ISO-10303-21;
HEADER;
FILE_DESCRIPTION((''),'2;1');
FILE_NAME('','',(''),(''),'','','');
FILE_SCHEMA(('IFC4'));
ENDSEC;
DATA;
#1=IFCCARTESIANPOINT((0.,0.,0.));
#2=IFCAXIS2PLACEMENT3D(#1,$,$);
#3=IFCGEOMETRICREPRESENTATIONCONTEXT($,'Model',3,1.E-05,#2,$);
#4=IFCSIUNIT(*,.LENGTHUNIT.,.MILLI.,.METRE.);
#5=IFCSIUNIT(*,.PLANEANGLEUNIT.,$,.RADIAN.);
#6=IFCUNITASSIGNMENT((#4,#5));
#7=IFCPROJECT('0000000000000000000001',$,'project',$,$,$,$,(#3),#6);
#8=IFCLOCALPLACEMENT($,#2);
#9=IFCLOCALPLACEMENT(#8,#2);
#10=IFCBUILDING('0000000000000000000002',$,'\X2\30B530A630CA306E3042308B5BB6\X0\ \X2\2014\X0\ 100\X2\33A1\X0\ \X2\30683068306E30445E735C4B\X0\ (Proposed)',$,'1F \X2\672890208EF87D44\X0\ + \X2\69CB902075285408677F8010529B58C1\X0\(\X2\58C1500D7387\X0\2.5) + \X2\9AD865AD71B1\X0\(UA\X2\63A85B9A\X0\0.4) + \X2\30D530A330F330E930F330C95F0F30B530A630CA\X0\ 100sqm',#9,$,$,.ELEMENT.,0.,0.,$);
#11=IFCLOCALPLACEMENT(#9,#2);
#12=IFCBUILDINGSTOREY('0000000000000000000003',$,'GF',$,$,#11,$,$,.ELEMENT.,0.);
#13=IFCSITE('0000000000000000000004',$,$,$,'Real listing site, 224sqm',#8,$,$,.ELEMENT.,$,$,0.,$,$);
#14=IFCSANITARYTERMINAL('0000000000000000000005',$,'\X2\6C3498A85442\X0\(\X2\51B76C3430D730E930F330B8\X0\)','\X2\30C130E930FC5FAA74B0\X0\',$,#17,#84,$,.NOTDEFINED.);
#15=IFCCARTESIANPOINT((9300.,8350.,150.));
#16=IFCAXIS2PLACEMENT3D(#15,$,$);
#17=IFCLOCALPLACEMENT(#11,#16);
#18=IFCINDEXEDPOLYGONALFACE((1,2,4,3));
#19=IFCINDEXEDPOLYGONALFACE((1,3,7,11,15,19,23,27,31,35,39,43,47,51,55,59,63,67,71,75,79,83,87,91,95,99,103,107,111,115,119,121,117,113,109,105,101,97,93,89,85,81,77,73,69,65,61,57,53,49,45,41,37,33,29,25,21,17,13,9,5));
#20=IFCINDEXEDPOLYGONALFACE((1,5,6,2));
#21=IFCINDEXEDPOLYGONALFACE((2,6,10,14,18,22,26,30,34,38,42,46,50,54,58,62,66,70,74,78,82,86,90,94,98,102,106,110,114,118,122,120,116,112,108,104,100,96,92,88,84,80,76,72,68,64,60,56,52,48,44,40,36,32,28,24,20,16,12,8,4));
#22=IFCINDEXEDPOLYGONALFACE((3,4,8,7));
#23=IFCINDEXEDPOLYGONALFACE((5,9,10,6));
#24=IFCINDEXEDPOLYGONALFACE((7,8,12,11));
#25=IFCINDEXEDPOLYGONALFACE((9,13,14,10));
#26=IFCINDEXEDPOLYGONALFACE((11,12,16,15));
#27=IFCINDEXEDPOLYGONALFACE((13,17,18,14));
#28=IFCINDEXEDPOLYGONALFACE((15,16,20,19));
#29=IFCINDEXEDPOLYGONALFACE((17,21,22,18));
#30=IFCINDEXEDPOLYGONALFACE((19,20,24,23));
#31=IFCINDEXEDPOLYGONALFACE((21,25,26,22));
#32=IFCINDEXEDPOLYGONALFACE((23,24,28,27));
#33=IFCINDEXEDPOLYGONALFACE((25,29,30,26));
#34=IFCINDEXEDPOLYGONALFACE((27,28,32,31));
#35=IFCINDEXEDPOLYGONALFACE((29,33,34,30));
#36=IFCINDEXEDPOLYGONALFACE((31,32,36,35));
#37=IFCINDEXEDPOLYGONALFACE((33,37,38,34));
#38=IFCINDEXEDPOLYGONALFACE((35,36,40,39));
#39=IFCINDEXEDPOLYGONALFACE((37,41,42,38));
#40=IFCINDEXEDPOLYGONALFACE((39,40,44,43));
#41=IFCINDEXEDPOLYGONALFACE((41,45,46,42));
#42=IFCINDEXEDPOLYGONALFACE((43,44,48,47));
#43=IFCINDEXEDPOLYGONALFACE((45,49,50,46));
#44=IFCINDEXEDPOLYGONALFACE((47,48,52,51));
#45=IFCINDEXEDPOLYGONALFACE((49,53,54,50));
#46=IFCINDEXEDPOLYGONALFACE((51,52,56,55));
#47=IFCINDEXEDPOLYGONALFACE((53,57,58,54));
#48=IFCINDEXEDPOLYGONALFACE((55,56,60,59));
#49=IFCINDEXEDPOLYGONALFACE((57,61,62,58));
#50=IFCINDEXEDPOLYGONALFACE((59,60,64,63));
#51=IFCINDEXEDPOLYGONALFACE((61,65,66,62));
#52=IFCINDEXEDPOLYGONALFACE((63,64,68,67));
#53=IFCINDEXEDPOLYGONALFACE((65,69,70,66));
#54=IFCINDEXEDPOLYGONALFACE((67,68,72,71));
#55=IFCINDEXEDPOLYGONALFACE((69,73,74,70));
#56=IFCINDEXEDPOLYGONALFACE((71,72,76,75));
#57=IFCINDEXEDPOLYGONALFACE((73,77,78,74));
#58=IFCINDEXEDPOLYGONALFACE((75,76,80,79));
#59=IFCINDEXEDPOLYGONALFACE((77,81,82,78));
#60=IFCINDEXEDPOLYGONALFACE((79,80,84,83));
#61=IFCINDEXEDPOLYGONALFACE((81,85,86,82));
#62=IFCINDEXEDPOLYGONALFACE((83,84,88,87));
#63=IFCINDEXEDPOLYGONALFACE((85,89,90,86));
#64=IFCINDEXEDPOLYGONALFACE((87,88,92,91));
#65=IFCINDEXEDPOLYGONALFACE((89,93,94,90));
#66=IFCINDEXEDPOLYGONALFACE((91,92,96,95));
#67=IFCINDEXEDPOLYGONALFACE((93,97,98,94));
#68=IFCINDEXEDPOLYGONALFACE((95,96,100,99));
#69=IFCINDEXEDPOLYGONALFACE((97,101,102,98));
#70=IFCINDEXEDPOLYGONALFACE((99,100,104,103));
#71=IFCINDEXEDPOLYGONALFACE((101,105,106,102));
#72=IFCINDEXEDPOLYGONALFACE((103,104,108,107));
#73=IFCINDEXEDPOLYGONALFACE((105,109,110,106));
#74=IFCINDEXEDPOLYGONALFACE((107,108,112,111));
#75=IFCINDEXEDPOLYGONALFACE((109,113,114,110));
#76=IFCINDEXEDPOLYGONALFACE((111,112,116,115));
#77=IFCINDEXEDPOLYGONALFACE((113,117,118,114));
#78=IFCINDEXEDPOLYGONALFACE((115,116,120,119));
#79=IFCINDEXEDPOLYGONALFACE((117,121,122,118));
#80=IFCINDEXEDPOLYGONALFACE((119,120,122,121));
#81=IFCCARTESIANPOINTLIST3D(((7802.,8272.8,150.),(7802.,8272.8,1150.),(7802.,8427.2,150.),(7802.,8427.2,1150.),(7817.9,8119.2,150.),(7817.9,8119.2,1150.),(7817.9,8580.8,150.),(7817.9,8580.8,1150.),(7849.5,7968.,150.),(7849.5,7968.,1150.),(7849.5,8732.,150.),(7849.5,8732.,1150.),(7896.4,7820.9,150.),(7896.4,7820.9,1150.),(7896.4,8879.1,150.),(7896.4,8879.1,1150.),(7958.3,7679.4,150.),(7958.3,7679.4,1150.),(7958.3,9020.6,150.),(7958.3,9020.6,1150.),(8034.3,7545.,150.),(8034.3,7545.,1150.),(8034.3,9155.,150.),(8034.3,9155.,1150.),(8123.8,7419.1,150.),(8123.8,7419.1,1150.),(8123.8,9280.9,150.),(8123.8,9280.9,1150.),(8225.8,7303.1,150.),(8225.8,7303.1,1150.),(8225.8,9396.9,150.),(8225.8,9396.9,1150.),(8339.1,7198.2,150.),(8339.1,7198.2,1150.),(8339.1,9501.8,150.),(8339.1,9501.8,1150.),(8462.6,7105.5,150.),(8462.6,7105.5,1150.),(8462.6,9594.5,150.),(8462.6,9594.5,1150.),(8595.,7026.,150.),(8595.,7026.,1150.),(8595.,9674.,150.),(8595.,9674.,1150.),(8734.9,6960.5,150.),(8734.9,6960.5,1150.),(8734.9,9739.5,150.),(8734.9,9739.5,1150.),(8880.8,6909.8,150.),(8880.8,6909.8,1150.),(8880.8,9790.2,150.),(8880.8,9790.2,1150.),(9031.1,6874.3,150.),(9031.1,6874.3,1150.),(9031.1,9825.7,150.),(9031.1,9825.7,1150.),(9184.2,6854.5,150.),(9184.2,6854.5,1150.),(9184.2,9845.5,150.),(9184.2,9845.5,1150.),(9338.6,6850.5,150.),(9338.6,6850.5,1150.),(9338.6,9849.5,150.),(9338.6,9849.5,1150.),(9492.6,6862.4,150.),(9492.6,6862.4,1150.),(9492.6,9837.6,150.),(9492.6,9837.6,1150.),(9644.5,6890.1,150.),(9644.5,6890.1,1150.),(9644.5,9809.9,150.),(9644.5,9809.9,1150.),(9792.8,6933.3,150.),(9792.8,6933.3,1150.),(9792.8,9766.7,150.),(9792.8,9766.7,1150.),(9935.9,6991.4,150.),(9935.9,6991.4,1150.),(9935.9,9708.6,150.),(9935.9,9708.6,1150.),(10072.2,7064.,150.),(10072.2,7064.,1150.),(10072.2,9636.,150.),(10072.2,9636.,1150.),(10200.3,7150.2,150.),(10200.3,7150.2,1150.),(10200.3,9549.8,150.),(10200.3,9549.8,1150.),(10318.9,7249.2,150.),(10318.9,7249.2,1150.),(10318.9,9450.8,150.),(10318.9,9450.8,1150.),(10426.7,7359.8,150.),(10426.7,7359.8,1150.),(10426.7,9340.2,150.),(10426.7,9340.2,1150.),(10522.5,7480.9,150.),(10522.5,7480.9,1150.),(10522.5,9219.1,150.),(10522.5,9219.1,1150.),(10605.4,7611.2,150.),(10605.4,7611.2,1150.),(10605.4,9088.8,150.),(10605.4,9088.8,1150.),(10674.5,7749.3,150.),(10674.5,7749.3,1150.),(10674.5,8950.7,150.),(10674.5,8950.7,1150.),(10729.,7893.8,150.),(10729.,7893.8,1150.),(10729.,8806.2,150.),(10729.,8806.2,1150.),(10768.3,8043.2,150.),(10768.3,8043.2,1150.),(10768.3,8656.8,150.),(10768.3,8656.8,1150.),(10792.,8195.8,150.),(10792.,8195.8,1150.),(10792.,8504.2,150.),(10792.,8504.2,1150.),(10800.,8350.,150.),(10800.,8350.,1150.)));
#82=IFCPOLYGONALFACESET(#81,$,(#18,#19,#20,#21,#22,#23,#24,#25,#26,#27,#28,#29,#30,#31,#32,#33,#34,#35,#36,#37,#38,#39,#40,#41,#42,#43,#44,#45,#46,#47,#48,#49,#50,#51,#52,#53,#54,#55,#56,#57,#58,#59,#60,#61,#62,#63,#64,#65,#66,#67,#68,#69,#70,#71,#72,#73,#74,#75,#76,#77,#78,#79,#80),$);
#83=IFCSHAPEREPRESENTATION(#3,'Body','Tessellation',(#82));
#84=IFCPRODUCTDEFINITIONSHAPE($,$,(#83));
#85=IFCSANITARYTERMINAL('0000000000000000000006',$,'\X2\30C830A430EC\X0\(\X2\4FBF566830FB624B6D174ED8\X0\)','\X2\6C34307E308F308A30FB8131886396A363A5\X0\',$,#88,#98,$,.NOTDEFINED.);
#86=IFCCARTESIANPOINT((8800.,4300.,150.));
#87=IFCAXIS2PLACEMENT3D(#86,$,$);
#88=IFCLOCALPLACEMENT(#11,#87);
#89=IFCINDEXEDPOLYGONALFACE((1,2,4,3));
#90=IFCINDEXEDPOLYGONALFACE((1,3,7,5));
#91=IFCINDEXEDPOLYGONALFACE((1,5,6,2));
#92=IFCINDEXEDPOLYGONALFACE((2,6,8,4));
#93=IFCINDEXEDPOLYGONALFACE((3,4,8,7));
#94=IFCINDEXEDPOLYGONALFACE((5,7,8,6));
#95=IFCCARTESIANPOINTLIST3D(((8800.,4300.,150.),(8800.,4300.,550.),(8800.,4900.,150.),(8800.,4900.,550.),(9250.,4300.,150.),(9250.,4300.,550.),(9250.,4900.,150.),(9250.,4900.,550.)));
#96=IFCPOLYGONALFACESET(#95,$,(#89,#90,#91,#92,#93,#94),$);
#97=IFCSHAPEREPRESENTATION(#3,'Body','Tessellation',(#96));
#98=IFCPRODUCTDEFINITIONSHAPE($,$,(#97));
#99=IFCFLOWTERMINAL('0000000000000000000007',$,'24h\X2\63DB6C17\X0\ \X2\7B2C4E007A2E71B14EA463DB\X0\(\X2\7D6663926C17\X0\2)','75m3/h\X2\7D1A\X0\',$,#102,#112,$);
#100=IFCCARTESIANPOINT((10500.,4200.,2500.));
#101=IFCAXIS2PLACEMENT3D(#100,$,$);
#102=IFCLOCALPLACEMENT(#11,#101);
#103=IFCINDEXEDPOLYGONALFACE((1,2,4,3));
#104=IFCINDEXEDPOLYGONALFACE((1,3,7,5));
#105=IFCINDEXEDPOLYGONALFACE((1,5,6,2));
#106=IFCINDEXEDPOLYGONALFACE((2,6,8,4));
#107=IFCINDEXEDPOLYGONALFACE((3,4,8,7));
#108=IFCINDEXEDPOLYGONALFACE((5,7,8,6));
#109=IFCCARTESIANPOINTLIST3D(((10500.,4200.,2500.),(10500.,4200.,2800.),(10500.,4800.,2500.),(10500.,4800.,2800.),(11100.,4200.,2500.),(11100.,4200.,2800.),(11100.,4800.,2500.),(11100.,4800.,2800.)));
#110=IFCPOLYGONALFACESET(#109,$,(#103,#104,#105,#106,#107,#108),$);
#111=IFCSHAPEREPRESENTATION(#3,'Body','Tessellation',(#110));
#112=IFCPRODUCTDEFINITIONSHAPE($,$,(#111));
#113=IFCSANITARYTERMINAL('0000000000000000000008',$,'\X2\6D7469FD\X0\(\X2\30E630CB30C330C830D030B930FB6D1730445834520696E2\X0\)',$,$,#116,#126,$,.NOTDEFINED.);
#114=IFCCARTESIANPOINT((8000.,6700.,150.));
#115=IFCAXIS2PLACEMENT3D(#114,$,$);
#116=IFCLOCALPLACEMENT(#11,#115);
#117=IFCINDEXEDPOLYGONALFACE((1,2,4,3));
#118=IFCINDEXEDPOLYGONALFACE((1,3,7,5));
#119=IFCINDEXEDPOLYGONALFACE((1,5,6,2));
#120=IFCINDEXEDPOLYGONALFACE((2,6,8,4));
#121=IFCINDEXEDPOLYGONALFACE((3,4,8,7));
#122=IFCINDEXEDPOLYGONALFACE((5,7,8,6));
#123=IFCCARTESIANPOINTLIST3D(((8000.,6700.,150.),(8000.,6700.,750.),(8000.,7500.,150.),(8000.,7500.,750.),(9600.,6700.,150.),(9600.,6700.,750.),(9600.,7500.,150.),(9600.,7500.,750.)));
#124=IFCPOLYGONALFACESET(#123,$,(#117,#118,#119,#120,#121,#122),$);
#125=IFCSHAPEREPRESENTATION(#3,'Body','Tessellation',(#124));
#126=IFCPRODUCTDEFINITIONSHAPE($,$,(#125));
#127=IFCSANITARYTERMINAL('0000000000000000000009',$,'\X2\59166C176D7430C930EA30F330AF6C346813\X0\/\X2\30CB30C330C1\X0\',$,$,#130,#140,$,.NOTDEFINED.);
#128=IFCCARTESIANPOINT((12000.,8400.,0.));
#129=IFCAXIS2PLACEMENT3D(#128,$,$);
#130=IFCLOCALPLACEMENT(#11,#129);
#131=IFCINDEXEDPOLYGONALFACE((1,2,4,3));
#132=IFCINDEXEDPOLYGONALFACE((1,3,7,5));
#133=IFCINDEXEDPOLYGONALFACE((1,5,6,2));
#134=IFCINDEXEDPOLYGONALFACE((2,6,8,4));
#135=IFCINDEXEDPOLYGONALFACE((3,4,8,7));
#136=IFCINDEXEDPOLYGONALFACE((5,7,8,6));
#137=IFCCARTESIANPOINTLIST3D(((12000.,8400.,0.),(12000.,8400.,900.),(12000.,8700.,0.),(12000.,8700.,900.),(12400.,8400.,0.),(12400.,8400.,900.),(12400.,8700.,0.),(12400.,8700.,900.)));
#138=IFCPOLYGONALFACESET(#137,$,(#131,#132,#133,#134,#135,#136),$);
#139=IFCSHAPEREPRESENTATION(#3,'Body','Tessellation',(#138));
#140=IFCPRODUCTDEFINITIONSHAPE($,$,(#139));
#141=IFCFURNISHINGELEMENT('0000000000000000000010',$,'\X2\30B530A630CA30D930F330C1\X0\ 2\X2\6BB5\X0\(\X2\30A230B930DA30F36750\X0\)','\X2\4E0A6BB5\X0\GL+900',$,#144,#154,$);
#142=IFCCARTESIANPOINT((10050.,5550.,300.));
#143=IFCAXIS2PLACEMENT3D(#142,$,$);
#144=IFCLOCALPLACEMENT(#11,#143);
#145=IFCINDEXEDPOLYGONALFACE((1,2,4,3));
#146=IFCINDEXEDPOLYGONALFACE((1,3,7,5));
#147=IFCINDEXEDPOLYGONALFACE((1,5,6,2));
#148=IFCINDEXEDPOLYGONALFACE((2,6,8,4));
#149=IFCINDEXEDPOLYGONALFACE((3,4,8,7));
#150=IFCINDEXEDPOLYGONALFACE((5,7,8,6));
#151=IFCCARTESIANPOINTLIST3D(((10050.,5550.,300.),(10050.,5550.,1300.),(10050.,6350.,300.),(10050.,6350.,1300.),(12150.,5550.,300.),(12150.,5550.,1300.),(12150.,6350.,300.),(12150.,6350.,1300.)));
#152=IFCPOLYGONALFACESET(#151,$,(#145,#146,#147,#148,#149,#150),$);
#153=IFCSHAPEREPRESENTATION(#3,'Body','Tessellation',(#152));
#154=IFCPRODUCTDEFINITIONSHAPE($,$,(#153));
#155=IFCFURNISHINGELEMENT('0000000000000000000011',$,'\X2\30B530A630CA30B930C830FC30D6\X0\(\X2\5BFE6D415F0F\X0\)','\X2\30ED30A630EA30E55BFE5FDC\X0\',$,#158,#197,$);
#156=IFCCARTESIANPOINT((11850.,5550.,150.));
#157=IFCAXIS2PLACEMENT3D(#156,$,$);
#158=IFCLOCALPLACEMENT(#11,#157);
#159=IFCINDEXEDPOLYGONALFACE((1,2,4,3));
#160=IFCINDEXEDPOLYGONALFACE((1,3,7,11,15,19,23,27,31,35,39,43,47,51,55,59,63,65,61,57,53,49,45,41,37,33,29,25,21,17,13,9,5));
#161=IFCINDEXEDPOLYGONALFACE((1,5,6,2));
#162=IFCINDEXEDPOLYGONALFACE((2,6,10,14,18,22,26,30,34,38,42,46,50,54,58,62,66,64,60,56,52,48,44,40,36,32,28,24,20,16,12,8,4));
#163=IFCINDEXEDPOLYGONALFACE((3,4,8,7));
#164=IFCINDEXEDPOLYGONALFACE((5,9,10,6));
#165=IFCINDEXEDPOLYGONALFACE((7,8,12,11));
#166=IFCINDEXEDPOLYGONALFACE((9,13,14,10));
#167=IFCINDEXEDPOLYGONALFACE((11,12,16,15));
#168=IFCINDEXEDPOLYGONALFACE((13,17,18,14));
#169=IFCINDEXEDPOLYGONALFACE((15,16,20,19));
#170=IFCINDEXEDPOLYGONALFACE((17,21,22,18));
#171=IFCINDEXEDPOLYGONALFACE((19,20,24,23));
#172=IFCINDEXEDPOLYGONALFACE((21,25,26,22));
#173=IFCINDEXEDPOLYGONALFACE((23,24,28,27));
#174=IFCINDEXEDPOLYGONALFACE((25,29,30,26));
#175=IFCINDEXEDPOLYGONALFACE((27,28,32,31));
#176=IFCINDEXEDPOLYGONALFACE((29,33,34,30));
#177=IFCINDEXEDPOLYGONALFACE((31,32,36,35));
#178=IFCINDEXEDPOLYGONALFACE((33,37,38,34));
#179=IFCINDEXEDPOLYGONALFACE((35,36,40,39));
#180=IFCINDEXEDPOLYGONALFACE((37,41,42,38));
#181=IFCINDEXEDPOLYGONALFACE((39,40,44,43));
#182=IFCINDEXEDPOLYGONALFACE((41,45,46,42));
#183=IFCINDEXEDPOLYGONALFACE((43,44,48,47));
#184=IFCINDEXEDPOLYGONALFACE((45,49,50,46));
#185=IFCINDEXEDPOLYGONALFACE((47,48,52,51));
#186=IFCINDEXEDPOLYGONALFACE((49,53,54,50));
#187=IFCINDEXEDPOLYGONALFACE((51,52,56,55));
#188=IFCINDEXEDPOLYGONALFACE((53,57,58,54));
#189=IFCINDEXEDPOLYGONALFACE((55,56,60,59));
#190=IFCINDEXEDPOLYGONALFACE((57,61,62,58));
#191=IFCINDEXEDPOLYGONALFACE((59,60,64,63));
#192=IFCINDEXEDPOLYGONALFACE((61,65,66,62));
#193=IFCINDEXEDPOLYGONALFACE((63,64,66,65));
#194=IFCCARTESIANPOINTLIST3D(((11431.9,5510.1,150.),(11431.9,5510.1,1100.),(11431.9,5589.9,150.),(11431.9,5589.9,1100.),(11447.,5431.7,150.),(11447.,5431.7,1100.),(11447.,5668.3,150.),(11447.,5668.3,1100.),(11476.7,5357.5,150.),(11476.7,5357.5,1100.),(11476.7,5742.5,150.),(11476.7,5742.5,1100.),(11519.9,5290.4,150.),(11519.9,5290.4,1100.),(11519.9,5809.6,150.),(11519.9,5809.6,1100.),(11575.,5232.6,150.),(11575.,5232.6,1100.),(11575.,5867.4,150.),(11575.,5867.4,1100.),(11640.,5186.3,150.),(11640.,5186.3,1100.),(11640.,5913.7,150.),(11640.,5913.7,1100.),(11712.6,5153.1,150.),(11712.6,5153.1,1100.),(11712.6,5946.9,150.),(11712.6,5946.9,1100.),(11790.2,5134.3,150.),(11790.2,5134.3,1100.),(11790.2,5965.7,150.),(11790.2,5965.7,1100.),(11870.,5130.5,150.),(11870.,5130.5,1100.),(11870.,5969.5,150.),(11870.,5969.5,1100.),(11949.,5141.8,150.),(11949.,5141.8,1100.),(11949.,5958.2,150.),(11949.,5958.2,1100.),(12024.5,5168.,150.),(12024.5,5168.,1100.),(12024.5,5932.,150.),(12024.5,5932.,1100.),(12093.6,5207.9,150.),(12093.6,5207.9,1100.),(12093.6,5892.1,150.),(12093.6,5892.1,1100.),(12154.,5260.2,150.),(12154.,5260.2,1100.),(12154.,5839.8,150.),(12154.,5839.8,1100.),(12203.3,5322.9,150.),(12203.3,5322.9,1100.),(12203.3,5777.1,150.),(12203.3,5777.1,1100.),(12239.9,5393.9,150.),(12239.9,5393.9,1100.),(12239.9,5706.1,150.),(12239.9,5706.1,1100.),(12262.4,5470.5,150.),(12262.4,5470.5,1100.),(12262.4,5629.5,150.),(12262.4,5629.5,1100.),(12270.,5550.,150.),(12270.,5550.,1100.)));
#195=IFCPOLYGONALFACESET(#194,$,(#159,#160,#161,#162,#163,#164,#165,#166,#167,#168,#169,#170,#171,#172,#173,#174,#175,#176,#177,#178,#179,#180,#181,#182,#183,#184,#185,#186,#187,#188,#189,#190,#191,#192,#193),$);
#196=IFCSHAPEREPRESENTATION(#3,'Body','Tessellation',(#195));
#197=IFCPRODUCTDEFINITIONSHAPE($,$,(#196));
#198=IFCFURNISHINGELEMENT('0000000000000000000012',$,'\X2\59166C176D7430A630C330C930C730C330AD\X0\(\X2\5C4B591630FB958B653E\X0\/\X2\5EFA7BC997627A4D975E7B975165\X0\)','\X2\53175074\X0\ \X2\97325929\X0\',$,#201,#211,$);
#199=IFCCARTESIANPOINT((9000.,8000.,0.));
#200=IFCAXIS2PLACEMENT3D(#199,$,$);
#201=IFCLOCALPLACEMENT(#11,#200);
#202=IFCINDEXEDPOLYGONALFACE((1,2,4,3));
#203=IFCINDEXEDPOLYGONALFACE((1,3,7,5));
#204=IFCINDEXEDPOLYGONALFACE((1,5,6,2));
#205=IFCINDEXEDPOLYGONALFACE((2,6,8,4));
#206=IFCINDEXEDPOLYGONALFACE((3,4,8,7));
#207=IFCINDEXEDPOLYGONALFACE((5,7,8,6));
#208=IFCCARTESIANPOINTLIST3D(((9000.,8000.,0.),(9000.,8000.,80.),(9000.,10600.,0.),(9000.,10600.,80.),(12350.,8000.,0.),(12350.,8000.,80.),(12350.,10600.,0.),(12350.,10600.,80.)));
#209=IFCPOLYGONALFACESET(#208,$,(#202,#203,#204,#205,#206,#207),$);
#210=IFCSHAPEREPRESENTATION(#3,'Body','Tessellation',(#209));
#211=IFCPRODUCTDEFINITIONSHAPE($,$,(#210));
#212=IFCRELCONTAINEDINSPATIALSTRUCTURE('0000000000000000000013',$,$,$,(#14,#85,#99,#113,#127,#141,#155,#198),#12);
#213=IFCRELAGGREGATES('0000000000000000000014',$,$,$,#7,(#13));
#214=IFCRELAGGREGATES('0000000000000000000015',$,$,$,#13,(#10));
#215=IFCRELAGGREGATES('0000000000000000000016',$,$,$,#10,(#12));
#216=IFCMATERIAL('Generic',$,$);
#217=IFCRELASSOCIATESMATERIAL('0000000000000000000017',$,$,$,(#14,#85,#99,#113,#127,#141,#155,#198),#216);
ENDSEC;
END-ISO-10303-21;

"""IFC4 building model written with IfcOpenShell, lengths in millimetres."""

from ifc_helpers import new_model, si_unit, frame, frame_2d, origin, origin_2d, place, context, project, spatial, rectangle, circle, extrude, material, element, save


model = new_model("IFC4")

# Units and contexts
model_context = context("Model", 3, precision=1e-05, world=origin())
ifc_project = project(units=[si_unit("LENGTHUNIT", "METRE", prefix="MILLI"), si_unit("PLANEANGLEUNIT", "RADIAN")], contexts=[model_context])

# Site, building, storey
site_placement = place(None, origin())
site = spatial("IfcSite", under=ifc_project, at=site_placement, ObjectType="Real listing site, 224sqm", CompositionType="ELEMENT", RefElevation=0.0)
building_placement = place(site_placement, origin())
building = spatial("IfcBuilding", under=site, at=building_placement, Name="サウナのある家 — 100㎡ ととのい平屋 (Proposed)", ObjectType="1F 木造軸組 + 構造用合板耐力壁(壁倍率2.5) + 高断熱(UA推定0.4) + フィンランド式サウナ 100sqm", CompositionType="ELEMENT", ElevationOfRefHeight=0.0, ElevationOfTerrain=0.0)
storey_placement = place(building_placement, origin())
storey = spatial("IfcBuildingStorey", under=building, at=storey_placement, Name="GF", CompositionType="ELEMENT", Elevation=0.0)

# Shared definitions
ifc_material = material(Name="Generic")

# Sanitary terminals
sanitary_terminal_1_placement = place(storey_placement, frame((9300.0, 8350.0, 150.0)))
element("IfcSanitaryTerminal", 1, at=sanitary_terminal_1_placement, inside=storey, material=ifc_material, Name="水風呂(冷水プランジ)", Description="チラー循環", PredefinedType="NOTDEFINED", context=model_context, shape_type="SweptSolid", body=[
    extrude(circle(Radius=1500.0, at=origin_2d()), frame((9300.0, 8350.0, 150.0)), (0.0, 0.0, 1.0), 1000.0),
])
sanitary_terminal_2_placement = place(storey_placement, frame((8800.0, 4300.0, 150.0)))
element("IfcSanitaryTerminal", 2, at=sanitary_terminal_2_placement, inside=storey, material=ifc_material, Name="トイレ(便器・手洗付)", Description="水まわり・脱衣隣接", PredefinedType="NOTDEFINED", context=model_context, shape_type="SweptSolid", body=[
    extrude(rectangle(XDim=450.0, YDim=600.0, at=frame_2d((225.0, 300.0))), frame((8800.0, 4300.0, 150.0)), (0.0, 0.0, 1.0), 400.0),
])

# Flow terminal
flow_terminal_placement = place(storey_placement, frame((10500.0, 4200.0, 2500.0)))
element("IfcFlowTerminal", 3, at=flow_terminal_placement, inside=storey, material=ifc_material, Name="24h換気 第一種熱交換(給排気2)", Description="75m3/h級", context=model_context, shape_type="SweptSolid", body=[
    extrude(rectangle(XDim=600.0, YDim=600.0, at=frame_2d((300.0, 300.0))), frame((10500.0, 4200.0, 2500.0)), (0.0, 0.0, 1.0), 300.0),
])

# Sanitary terminals
sanitary_terminal_3_placement = place(storey_placement, frame((8000.0, 6700.0, 150.0)))
element("IfcSanitaryTerminal", 4, at=sanitary_terminal_3_placement, inside=storey, material=ifc_material, Name="浴槽(ユニットバス・洗い場分離)", PredefinedType="NOTDEFINED", context=model_context, shape_type="SweptSolid", body=[
    extrude(rectangle(XDim=1600.0, YDim=800.0, at=frame_2d((800.0, 400.0))), frame((8000.0, 6700.0, 150.0)), (0.0, 0.0, 1.0), 600.0),
])
sanitary_terminal_4_placement = place(storey_placement, frame((12000.0, 8400.0, 0.0)))
element("IfcSanitaryTerminal", 5, at=sanitary_terminal_4_placement, inside=storey, material=ifc_material, Name="外気浴ドリンク水栓/ニッチ", PredefinedType="NOTDEFINED", context=model_context, shape_type="SweptSolid", body=[
    extrude(rectangle(XDim=400.0, YDim=300.0, at=frame_2d((200.0, 150.0))), frame((12000.0, 8400.0, 0.0)), (0.0, 0.0, 1.0), 900.0),
])

# Furnishing elements
furnishing_1_placement = place(storey_placement, frame((10050.0, 5550.0, 300.0)))
element("IfcFurnishingElement", 6, at=furnishing_1_placement, inside=storey, material=ifc_material, Name="サウナベンチ 2段(アスペン材)", Description="上段GL+900", context=model_context, shape_type="SweptSolid", body=[
    extrude(rectangle(XDim=2100.0, YDim=800.0, at=frame_2d((1050.0, 400.0))), frame((10050.0, 5550.0, 300.0)), (0.0, 0.0, 1.0), 1000.0),
])
furnishing_2_placement = place(storey_placement, frame((11850.0, 5550.0, 150.0)))
element("IfcFurnishingElement", 7, at=furnishing_2_placement, inside=storey, material=ifc_material, Name="サウナストーブ(対流式)", Description="ロウリュ対応", context=model_context, shape_type="SweptSolid", body=[
    extrude(circle(Radius=420.0, at=origin_2d()), frame((11850.0, 5550.0, 150.0)), (0.0, 0.0, 1.0), 950.0),
])
furnishing_3_placement = place(storey_placement, frame((9000.0, 8000.0, 0.0)))
element("IfcFurnishingElement", 8, at=furnishing_3_placement, inside=storey, material=ifc_material, Name="外気浴ウッドデッキ(屋外・開放/建築面積非算入)", Description="北側 露天", context=model_context, shape_type="SweptSolid", body=[
    extrude(rectangle(XDim=3350.0, YDim=2600.0, at=frame_2d((1675.0, 1300.0))), frame((9000.0, 8000.0, 0.0)), (0.0, 0.0, 1.0), 80.0),
])

save(model, "model.ifc")
